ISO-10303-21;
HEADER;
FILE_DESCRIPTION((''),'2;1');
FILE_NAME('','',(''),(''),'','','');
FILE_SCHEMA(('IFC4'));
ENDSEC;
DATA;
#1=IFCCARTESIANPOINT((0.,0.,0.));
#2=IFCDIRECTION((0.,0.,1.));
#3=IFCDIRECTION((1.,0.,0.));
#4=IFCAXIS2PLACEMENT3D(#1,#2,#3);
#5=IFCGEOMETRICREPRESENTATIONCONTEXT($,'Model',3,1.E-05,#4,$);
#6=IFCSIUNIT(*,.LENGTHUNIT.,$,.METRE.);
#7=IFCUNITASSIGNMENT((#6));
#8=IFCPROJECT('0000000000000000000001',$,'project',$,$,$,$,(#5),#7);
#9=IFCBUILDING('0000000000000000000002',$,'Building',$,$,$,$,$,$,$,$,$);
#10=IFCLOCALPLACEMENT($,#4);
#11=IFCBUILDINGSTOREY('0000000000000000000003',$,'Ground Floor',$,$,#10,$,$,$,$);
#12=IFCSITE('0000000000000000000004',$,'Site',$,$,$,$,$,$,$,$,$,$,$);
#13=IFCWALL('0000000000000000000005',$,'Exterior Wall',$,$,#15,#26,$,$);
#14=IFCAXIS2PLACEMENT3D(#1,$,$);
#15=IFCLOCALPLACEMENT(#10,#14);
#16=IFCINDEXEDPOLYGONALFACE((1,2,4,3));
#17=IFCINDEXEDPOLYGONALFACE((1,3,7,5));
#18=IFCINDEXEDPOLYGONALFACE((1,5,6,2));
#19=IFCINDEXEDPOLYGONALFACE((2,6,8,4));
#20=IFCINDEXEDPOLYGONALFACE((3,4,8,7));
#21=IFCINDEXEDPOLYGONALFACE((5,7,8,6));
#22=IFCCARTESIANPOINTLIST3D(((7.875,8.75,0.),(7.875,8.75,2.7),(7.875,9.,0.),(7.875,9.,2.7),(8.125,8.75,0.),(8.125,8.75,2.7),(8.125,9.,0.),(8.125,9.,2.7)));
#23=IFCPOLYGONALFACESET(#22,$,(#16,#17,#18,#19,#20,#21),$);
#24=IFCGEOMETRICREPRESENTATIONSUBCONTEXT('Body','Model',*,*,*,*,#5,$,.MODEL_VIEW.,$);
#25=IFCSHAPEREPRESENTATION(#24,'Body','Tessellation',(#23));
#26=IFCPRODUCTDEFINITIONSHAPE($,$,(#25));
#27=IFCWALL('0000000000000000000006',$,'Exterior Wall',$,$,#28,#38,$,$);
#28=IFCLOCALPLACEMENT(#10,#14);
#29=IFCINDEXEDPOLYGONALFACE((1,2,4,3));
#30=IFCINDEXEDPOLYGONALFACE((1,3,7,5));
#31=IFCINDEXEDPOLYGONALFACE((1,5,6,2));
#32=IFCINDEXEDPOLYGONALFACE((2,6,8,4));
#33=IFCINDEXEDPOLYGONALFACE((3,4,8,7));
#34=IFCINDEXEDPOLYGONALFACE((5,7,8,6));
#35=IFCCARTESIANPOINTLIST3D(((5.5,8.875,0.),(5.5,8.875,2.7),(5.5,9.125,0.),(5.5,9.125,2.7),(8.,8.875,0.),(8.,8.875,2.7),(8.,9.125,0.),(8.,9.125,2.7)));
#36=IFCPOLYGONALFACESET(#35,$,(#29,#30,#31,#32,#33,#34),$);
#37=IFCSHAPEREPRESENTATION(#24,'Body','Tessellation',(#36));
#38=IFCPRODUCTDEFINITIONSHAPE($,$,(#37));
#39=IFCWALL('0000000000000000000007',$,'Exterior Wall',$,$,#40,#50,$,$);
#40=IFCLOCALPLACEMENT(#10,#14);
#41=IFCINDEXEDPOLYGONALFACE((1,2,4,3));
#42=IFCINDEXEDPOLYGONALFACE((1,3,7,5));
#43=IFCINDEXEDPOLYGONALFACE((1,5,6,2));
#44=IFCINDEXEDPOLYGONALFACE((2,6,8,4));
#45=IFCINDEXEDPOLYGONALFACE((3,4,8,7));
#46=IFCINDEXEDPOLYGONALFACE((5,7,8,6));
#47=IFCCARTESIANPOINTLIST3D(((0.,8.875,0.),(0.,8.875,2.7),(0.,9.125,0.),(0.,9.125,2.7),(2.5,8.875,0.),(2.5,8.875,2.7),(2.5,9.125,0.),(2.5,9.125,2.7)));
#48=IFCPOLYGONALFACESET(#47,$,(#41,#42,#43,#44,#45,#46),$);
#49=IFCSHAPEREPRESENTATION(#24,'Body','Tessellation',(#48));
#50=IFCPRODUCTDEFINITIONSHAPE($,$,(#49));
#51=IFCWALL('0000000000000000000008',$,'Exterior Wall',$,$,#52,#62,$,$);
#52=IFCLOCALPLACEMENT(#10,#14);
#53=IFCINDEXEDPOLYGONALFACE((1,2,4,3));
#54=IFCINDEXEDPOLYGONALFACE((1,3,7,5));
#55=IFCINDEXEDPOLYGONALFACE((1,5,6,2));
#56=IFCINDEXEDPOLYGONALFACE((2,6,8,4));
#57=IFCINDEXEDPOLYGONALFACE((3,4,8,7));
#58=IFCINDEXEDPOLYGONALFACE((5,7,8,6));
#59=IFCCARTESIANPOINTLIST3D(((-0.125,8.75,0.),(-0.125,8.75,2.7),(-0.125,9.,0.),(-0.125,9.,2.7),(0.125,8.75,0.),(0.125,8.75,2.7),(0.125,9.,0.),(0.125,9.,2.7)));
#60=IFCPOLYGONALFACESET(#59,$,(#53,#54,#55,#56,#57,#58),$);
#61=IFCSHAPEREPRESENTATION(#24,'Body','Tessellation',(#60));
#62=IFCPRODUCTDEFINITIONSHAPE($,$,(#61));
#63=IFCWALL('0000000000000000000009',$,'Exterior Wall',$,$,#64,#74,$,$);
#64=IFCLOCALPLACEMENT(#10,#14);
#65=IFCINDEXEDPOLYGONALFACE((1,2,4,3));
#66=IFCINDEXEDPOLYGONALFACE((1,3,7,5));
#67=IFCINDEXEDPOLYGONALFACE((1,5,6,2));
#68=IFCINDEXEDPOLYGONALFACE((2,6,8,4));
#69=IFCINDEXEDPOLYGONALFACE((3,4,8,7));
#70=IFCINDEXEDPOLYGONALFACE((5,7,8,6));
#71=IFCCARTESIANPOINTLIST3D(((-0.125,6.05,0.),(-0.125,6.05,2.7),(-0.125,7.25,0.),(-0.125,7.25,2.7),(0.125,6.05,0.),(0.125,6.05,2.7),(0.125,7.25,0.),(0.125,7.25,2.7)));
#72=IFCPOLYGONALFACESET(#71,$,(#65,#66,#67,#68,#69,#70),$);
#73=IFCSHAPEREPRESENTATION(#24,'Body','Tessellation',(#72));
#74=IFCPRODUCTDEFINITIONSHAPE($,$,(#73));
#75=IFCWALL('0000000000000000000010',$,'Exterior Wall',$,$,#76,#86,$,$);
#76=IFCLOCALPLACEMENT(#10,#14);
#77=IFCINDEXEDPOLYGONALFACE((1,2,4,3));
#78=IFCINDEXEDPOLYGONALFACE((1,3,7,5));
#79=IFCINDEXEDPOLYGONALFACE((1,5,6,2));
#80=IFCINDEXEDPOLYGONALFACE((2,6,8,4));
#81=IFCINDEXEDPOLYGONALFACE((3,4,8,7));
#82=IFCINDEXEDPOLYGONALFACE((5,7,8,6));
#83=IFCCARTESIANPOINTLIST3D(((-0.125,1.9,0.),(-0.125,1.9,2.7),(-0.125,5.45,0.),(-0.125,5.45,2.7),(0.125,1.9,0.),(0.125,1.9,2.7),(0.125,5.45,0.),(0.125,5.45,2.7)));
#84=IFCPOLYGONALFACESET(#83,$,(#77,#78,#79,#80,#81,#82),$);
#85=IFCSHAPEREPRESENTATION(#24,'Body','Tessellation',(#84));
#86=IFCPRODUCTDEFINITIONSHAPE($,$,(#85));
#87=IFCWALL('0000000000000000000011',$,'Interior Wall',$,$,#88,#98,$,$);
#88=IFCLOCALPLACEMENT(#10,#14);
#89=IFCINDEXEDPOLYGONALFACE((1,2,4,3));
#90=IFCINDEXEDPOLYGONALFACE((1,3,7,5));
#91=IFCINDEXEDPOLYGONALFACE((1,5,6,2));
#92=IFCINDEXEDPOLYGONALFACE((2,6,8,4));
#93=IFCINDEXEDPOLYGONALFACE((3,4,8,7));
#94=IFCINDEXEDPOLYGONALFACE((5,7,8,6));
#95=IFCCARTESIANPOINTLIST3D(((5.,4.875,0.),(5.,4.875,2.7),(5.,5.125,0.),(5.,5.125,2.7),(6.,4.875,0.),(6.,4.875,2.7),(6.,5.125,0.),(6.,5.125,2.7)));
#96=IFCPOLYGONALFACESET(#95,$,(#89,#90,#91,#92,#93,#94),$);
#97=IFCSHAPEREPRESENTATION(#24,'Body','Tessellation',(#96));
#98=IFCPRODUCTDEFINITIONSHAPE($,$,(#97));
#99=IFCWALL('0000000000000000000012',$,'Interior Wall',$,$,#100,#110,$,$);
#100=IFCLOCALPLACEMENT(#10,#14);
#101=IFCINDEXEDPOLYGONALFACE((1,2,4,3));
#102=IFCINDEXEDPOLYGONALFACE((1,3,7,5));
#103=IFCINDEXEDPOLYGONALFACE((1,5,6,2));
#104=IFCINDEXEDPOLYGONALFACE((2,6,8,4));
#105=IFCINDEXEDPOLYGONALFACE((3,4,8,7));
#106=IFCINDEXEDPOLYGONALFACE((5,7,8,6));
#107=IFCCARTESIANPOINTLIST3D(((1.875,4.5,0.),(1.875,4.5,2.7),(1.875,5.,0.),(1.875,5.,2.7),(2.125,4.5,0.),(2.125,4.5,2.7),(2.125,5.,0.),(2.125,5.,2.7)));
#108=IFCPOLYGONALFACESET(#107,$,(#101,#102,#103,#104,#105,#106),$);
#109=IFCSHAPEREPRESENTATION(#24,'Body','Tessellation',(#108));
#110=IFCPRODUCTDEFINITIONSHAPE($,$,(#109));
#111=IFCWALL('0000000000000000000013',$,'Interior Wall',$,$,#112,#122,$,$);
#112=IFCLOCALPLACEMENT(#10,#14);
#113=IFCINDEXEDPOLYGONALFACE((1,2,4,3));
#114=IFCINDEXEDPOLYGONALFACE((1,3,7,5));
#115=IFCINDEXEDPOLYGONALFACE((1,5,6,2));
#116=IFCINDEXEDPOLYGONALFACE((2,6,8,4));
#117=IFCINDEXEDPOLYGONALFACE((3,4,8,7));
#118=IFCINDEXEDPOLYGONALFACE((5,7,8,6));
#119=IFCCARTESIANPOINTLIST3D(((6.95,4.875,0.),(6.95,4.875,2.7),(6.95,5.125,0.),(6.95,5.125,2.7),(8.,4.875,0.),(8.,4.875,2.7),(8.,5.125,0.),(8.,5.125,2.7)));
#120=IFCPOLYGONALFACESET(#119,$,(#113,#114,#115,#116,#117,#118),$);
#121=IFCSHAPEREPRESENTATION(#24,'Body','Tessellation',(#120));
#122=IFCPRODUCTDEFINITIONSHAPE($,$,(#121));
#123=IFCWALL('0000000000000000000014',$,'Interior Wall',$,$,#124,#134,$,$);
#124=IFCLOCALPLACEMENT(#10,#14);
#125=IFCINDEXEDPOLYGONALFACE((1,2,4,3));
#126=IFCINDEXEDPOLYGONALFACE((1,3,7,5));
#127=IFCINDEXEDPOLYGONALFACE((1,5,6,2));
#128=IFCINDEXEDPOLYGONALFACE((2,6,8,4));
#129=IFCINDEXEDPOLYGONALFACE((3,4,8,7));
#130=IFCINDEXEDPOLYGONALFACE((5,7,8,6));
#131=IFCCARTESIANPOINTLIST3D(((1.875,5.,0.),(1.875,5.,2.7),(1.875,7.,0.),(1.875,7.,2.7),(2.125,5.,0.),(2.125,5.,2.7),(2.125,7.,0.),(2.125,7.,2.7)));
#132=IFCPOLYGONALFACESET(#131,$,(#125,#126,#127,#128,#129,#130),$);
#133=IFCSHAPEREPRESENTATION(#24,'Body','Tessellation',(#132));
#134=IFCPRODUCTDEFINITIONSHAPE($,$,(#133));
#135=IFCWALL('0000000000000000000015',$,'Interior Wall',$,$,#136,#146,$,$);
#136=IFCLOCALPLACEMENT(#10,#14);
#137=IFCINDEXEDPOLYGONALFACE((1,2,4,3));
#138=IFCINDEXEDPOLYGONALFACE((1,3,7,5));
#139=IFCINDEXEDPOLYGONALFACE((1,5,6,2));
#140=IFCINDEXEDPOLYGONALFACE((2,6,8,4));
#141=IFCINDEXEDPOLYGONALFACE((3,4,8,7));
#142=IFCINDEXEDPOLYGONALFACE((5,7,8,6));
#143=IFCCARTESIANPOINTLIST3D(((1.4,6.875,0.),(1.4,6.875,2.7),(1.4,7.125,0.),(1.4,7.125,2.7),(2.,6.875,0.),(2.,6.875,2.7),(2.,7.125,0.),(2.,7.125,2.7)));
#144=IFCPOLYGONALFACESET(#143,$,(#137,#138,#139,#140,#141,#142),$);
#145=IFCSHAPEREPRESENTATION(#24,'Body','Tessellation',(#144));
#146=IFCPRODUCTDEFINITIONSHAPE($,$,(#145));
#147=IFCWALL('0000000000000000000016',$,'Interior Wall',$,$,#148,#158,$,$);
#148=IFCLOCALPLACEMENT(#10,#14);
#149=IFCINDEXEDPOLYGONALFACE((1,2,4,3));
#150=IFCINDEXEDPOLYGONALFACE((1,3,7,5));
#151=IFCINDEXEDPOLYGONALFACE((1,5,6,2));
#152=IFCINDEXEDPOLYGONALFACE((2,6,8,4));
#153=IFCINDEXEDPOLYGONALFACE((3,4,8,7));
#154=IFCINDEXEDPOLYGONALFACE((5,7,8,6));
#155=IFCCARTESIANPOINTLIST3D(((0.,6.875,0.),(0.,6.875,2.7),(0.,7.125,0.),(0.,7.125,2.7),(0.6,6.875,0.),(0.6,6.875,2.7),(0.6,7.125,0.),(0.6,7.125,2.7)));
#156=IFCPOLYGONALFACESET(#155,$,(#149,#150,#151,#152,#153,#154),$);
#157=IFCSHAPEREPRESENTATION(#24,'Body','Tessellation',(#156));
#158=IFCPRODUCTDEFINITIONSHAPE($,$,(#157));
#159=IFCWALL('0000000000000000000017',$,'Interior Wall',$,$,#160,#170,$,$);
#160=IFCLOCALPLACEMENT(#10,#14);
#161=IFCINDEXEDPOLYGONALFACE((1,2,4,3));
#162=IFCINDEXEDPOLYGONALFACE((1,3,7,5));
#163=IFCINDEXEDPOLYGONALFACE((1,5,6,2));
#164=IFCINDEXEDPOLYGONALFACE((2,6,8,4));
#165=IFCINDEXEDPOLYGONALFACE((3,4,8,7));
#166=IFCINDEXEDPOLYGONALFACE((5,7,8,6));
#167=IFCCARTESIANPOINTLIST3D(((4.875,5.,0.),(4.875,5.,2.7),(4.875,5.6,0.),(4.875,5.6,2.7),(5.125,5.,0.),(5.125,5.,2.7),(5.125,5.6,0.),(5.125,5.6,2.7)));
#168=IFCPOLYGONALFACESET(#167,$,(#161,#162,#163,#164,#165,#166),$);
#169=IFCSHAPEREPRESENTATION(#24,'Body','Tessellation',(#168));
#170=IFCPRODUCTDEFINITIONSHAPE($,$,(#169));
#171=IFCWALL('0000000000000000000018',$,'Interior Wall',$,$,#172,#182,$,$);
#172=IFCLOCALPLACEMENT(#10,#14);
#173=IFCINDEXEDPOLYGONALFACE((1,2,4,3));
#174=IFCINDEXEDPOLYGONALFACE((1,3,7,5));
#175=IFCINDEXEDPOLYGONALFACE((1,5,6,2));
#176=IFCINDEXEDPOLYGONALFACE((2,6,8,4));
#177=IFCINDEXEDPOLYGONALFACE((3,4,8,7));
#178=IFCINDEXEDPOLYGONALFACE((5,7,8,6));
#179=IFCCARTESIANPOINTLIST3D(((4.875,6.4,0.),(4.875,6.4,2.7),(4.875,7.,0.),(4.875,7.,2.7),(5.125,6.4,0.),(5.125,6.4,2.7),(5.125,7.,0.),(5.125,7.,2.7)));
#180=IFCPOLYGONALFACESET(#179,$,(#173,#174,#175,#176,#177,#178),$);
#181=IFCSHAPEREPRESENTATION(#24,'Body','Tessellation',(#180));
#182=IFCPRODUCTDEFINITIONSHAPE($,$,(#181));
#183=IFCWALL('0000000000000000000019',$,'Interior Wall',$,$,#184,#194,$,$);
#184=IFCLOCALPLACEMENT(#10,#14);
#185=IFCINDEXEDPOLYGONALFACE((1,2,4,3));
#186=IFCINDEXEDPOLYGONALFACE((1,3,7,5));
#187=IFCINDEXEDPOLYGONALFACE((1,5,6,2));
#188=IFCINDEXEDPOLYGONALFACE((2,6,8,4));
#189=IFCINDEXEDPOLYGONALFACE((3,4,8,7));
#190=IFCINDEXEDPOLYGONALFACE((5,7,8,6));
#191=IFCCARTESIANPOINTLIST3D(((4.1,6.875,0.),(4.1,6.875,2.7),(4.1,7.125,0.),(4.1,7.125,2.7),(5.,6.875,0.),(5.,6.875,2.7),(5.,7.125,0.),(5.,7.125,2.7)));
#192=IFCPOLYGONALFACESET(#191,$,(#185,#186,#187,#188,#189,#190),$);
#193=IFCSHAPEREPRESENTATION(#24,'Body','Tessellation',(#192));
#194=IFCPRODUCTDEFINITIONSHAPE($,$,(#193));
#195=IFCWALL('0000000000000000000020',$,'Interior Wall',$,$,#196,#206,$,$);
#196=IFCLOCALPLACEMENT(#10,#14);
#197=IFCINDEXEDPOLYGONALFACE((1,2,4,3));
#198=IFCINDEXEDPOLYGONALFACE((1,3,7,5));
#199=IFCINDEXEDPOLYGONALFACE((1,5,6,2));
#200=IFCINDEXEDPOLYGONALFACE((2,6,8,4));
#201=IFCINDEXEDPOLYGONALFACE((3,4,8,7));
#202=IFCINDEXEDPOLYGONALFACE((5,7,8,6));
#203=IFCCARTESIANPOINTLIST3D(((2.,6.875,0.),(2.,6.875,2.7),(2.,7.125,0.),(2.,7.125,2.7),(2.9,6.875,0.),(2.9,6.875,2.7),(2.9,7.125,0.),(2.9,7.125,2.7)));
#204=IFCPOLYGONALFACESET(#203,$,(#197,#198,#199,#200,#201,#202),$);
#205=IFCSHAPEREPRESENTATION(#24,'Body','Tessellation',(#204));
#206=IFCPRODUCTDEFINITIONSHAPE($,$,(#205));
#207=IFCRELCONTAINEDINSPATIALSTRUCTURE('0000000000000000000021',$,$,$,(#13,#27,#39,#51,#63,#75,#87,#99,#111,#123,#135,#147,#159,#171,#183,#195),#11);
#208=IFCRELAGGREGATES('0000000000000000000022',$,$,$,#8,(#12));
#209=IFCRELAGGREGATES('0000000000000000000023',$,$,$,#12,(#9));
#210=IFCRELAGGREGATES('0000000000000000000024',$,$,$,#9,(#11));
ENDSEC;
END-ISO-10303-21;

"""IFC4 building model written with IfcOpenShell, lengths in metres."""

from ifc_helpers import new_model, si_unit, frame, origin_with_axes, place, context, subcontext, project, spatial, indexed_curve, outline, extrude, element, save


model = new_model("IFC4")

# Units and contexts
model_context = context("Model", 3, precision=1e-05, world=origin_with_axes())
body_context = subcontext(model_context, "Body", "Model", "MODEL_VIEW")
ifc_project = project(units=[si_unit("LENGTHUNIT", "METRE")], contexts=[model_context])

# Site, building, storey
site = spatial("IfcSite", under=ifc_project, Name="Site")
building = spatial("IfcBuilding", under=site, Name="Building")
storey_placement = place(None, origin_with_axes())
storey = spatial("IfcBuildingStorey", under=building, at=storey_placement, Name="Ground Floor")

# Walls
wall_1_placement = place(storey_placement, frame((8.0, 8.75, 0.0), z_axis=(0.0, 0.0, 1.0), x_axis=(0.0, 1.0, 0.0)))
element("IfcWall", 1, at=wall_1_placement, inside=storey, Name="Exterior Wall", context=body_context, shape_type="SweptSolid", body=[
    extrude(outline(indexed_curve([(0.0, 0.0), (0.0, 0.25), (0.25, 0.25), (0.25, 0.0), (0.0, 0.0)], self_intersect=False)), frame((0.0, -0.125, 0.0), z_axis=(0.0, 0.0, 1.0), x_axis=(1.0, 0.0, 0.0)), (0.0, 0.0, 1.0), 2.7),
])
for number, where, z_axis, x_axis, name in (
    (2, (8.0, 9.0, 0.0), (0.0, 0.0, 1.0), (-1.0, 0.0, 0.0), "Exterior Wall"),
    (3, (2.5, 9.0, 0.0), (0.0, 0.0, 1.0), (-1.0, 0.0, 0.0), "Exterior Wall"),
):
    element("IfcWall", number, at=place(storey_placement, frame(where, z_axis=z_axis, x_axis=x_axis)), inside=storey, Name=name, context=body_context, shape_type="SweptSolid", body=[
        extrude(outline(indexed_curve([(0.0, 0.0), (0.0, 0.25), (2.5, 0.25), (2.5, 0.0), (0.0, 0.0)], self_intersect=False)), frame((0.0, -0.125, 0.0), z_axis=(0.0, 0.0, 1.0), x_axis=(1.0, 0.0, 0.0)), (0.0, 0.0, 1.0), 2.7),
    ])
wall_2_placement = place(storey_placement, frame((0.0, 9.0, 0.0), z_axis=(0.0, 0.0, 1.0), x_axis=(0.0, -1.0, 0.0)))
element("IfcWall", 4, at=wall_2_placement, inside=storey, Name="Exterior Wall", context=body_context, shape_type="SweptSolid", body=[
    extrude(outline(indexed_curve([(0.0, 0.0), (0.0, 0.25), (0.25, 0.25), (0.25, 0.0), (0.0, 0.0)], self_intersect=False)), frame((0.0, -0.125, 0.0), z_axis=(0.0, 0.0, 1.0), x_axis=(1.0, 0.0, 0.0)), (0.0, 0.0, 1.0), 2.7),
])
wall_3_placement = place(storey_placement, frame((0.0, 7.25, 0.0), z_axis=(0.0, 0.0, 1.0), x_axis=(0.0, -1.0, 0.0)))
element("IfcWall", 5, at=wall_3_placement, inside=storey, Name="Exterior Wall", context=body_context, shape_type="SweptSolid", body=[
    extrude(outline(indexed_curve([(0.0, 0.0), (0.0, 0.25), (1.2, 0.25), (1.2, 0.0), (0.0, 0.0)], self_intersect=False)), frame((0.0, -0.125, 0.0), z_axis=(0.0, 0.0, 1.0), x_axis=(1.0, 0.0, 0.0)), (0.0, 0.0, 1.0), 2.7),
])
wall_4_placement = place(storey_placement, frame((0.0, 5.45, 0.0), z_axis=(0.0, 0.0, 1.0), x_axis=(0.0, -1.0, 0.0)))
element("IfcWall", 6, at=wall_4_placement, inside=storey, Name="Exterior Wall", context=body_context, shape_type="SweptSolid", body=[
    extrude(outline(indexed_curve([(0.0, 0.0), (0.0, 0.25), (3.55, 0.25), (3.55, 0.0), (0.0, 0.0)], self_intersect=False)), frame((0.0, -0.125, 0.0), z_axis=(0.0, 0.0, 1.0), x_axis=(1.0, 0.0, 0.0)), (0.0, 0.0, 1.0), 2.7),
])
wall_5_placement = place(storey_placement, frame((6.0, 5.0, 0.0), z_axis=(0.0, 0.0, 1.0), x_axis=(-1.0, 0.0, 0.0)))
element("IfcWall", 7, at=wall_5_placement, inside=storey, Name="Interior Wall", context=body_context, shape_type="SweptSolid", body=[
    extrude(outline(indexed_curve([(0.0, 0.0), (0.0, 0.25), (1.0, 0.25), (1.0, 0.0), (0.0, 0.0)], self_intersect=False)), frame((0.0, -0.125, 0.0), z_axis=(0.0, 0.0, 1.0), x_axis=(1.0, 0.0, 0.0)), (0.0, 0.0, 1.0), 2.7),
])
wall_6_placement = place(storey_placement, frame((2.0, 5.0, 0.0), z_axis=(0.0, 0.0, 1.0), x_axis=(0.0, -1.0, 0.0)))
element("IfcWall", 8, at=wall_6_placement, inside=storey, Name="Interior Wall", context=body_context, shape_type="SweptSolid", body=[
    extrude(outline(indexed_curve([(0.0, 0.0), (0.0, 0.25), (0.5, 0.25), (0.5, 0.0), (0.0, 0.0)], self_intersect=False)), frame((0.0, -0.125, 0.0), z_axis=(0.0, 0.0, 1.0), x_axis=(1.0, 0.0, 0.0)), (0.0, 0.0, 1.0), 2.7),
])
wall_7_placement = place(storey_placement, frame((8.0, 5.0, 0.0), z_axis=(0.0, 0.0, 1.0), x_axis=(-1.0, 0.0, 0.0)))
element("IfcWall", 9, at=wall_7_placement, inside=storey, Name="Interior Wall", context=body_context, shape_type="SweptSolid", body=[
    extrude(outline(indexed_curve([(0.0, 0.0), (0.0, 0.25), (1.05, 0.25), (1.05, 0.0), (0.0, 0.0)], self_intersect=False)), frame((0.0, -0.125, 0.0), z_axis=(0.0, 0.0, 1.0), x_axis=(1.0, 0.0, 0.0)), (0.0, 0.0, 1.0), 2.7),
])
wall_8_placement = place(storey_placement, frame((2.0, 5.0, 0.0), z_axis=(0.0, 0.0, 1.0), x_axis=(0.0, 1.0, 0.0)))
element("IfcWall", 10, at=wall_8_placement, inside=storey, Name="Interior Wall", context=body_context, shape_type="SweptSolid", body=[
    extrude(outline(indexed_curve([(0.0, 0.0), (0.0, 0.25), (2.0, 0.25), (2.0, 0.0), (0.0, 0.0)], self_intersect=False)), frame((0.0, -0.125, 0.0), z_axis=(0.0, 0.0, 1.0), x_axis=(1.0, 0.0, 0.0)), (0.0, 0.0, 1.0), 2.7),
])
for number, where, z_axis, x_axis, name in (
    (11, (2.0, 7.0, 0.0), (0.0, 0.0, 1.0), (-1.0, 0.0, 0.0), "Interior Wall"),
    (12, (0.6, 7.0, 0.0), (0.0, 0.0, 1.0), (-1.0, 0.0, 0.0), "Interior Wall"),
):
    element("IfcWall", number, at=place(storey_placement, frame(where, z_axis=z_axis, x_axis=x_axis)), inside=storey, Name=name, context=body_context, shape_type="SweptSolid", body=[
        extrude(outline(indexed_curve([(0.0, 0.0), (0.0, 0.25), (0.6, 0.25), (0.6, 0.0), (0.0, 0.0)], self_intersect=False)), frame((0.0, -0.125, 0.0), z_axis=(0.0, 0.0, 1.0), x_axis=(1.0, 0.0, 0.0)), (0.0, 0.0, 1.0), 2.7),
    ])
for number, where, z_axis, x_axis, name in (
    (13, (5.0, 5.0, 0.0), (0.0, 0.0, 1.0), (0.0, 1.0, 0.0), "Interior Wall"),
    (14, (5.0, 6.4, 0.0), (0.0, 0.0, 1.0), (0.0, 1.0, 0.0), "Interior Wall"),
):
    element("IfcWall", number, at=place(storey_placement, frame(where, z_axis=z_axis, x_axis=x_axis)), inside=storey, Name=name, context=body_context, shape_type="SweptSolid", body=[
        extrude(outline(indexed_curve([(0.0, 0.0), (0.0, 0.25), (0.6, 0.25), (0.6, 0.0), (0.0, 0.0)], self_intersect=False)), frame((0.0, -0.125, 0.0), z_axis=(0.0, 0.0, 1.0), x_axis=(1.0, 0.0, 0.0)), (0.0, 0.0, 1.0), 2.7),
    ])
wall_9_placement = place(storey_placement, frame((5.0, 7.0, 0.0), z_axis=(0.0, 0.0, 1.0), x_axis=(-1.0, 0.0, 0.0)))
element("IfcWall", 15, at=wall_9_placement, inside=storey, Name="Interior Wall", context=body_context, shape_type="SweptSolid", body=[
    extrude(outline(indexed_curve([(0.0, 0.0), (0.0, 0.25), (0.9, 0.25), (0.9, 0.0), (0.0, 0.0)], self_intersect=False)), frame((0.0, -0.125, 0.0), z_axis=(0.0, 0.0, 1.0), x_axis=(1.0, 0.0, 0.0)), (0.0, 0.0, 1.0), 2.7),
])
wall_10_placement = place(storey_placement, frame((2.9, 7.0, 0.0), z_axis=(0.0, 0.0, 1.0), x_axis=(-1.0, 0.0, 0.0)))
element("IfcWall", 16, at=wall_10_placement, inside=storey, Name="Interior Wall", context=body_context, shape_type="SweptSolid", body=[
    extrude(outline(indexed_curve([(0.0, 0.0), (0.0, 0.25), (0.9, 0.25), (0.9, 0.0), (0.0, 0.0)], self_intersect=False)), frame((0.0, -0.125, 0.0), z_axis=(0.0, 0.0, 1.0), x_axis=(1.0, 0.0, 0.0)), (0.0, 0.0, 1.0), 2.7),
])

save(model, "model.ifc")
